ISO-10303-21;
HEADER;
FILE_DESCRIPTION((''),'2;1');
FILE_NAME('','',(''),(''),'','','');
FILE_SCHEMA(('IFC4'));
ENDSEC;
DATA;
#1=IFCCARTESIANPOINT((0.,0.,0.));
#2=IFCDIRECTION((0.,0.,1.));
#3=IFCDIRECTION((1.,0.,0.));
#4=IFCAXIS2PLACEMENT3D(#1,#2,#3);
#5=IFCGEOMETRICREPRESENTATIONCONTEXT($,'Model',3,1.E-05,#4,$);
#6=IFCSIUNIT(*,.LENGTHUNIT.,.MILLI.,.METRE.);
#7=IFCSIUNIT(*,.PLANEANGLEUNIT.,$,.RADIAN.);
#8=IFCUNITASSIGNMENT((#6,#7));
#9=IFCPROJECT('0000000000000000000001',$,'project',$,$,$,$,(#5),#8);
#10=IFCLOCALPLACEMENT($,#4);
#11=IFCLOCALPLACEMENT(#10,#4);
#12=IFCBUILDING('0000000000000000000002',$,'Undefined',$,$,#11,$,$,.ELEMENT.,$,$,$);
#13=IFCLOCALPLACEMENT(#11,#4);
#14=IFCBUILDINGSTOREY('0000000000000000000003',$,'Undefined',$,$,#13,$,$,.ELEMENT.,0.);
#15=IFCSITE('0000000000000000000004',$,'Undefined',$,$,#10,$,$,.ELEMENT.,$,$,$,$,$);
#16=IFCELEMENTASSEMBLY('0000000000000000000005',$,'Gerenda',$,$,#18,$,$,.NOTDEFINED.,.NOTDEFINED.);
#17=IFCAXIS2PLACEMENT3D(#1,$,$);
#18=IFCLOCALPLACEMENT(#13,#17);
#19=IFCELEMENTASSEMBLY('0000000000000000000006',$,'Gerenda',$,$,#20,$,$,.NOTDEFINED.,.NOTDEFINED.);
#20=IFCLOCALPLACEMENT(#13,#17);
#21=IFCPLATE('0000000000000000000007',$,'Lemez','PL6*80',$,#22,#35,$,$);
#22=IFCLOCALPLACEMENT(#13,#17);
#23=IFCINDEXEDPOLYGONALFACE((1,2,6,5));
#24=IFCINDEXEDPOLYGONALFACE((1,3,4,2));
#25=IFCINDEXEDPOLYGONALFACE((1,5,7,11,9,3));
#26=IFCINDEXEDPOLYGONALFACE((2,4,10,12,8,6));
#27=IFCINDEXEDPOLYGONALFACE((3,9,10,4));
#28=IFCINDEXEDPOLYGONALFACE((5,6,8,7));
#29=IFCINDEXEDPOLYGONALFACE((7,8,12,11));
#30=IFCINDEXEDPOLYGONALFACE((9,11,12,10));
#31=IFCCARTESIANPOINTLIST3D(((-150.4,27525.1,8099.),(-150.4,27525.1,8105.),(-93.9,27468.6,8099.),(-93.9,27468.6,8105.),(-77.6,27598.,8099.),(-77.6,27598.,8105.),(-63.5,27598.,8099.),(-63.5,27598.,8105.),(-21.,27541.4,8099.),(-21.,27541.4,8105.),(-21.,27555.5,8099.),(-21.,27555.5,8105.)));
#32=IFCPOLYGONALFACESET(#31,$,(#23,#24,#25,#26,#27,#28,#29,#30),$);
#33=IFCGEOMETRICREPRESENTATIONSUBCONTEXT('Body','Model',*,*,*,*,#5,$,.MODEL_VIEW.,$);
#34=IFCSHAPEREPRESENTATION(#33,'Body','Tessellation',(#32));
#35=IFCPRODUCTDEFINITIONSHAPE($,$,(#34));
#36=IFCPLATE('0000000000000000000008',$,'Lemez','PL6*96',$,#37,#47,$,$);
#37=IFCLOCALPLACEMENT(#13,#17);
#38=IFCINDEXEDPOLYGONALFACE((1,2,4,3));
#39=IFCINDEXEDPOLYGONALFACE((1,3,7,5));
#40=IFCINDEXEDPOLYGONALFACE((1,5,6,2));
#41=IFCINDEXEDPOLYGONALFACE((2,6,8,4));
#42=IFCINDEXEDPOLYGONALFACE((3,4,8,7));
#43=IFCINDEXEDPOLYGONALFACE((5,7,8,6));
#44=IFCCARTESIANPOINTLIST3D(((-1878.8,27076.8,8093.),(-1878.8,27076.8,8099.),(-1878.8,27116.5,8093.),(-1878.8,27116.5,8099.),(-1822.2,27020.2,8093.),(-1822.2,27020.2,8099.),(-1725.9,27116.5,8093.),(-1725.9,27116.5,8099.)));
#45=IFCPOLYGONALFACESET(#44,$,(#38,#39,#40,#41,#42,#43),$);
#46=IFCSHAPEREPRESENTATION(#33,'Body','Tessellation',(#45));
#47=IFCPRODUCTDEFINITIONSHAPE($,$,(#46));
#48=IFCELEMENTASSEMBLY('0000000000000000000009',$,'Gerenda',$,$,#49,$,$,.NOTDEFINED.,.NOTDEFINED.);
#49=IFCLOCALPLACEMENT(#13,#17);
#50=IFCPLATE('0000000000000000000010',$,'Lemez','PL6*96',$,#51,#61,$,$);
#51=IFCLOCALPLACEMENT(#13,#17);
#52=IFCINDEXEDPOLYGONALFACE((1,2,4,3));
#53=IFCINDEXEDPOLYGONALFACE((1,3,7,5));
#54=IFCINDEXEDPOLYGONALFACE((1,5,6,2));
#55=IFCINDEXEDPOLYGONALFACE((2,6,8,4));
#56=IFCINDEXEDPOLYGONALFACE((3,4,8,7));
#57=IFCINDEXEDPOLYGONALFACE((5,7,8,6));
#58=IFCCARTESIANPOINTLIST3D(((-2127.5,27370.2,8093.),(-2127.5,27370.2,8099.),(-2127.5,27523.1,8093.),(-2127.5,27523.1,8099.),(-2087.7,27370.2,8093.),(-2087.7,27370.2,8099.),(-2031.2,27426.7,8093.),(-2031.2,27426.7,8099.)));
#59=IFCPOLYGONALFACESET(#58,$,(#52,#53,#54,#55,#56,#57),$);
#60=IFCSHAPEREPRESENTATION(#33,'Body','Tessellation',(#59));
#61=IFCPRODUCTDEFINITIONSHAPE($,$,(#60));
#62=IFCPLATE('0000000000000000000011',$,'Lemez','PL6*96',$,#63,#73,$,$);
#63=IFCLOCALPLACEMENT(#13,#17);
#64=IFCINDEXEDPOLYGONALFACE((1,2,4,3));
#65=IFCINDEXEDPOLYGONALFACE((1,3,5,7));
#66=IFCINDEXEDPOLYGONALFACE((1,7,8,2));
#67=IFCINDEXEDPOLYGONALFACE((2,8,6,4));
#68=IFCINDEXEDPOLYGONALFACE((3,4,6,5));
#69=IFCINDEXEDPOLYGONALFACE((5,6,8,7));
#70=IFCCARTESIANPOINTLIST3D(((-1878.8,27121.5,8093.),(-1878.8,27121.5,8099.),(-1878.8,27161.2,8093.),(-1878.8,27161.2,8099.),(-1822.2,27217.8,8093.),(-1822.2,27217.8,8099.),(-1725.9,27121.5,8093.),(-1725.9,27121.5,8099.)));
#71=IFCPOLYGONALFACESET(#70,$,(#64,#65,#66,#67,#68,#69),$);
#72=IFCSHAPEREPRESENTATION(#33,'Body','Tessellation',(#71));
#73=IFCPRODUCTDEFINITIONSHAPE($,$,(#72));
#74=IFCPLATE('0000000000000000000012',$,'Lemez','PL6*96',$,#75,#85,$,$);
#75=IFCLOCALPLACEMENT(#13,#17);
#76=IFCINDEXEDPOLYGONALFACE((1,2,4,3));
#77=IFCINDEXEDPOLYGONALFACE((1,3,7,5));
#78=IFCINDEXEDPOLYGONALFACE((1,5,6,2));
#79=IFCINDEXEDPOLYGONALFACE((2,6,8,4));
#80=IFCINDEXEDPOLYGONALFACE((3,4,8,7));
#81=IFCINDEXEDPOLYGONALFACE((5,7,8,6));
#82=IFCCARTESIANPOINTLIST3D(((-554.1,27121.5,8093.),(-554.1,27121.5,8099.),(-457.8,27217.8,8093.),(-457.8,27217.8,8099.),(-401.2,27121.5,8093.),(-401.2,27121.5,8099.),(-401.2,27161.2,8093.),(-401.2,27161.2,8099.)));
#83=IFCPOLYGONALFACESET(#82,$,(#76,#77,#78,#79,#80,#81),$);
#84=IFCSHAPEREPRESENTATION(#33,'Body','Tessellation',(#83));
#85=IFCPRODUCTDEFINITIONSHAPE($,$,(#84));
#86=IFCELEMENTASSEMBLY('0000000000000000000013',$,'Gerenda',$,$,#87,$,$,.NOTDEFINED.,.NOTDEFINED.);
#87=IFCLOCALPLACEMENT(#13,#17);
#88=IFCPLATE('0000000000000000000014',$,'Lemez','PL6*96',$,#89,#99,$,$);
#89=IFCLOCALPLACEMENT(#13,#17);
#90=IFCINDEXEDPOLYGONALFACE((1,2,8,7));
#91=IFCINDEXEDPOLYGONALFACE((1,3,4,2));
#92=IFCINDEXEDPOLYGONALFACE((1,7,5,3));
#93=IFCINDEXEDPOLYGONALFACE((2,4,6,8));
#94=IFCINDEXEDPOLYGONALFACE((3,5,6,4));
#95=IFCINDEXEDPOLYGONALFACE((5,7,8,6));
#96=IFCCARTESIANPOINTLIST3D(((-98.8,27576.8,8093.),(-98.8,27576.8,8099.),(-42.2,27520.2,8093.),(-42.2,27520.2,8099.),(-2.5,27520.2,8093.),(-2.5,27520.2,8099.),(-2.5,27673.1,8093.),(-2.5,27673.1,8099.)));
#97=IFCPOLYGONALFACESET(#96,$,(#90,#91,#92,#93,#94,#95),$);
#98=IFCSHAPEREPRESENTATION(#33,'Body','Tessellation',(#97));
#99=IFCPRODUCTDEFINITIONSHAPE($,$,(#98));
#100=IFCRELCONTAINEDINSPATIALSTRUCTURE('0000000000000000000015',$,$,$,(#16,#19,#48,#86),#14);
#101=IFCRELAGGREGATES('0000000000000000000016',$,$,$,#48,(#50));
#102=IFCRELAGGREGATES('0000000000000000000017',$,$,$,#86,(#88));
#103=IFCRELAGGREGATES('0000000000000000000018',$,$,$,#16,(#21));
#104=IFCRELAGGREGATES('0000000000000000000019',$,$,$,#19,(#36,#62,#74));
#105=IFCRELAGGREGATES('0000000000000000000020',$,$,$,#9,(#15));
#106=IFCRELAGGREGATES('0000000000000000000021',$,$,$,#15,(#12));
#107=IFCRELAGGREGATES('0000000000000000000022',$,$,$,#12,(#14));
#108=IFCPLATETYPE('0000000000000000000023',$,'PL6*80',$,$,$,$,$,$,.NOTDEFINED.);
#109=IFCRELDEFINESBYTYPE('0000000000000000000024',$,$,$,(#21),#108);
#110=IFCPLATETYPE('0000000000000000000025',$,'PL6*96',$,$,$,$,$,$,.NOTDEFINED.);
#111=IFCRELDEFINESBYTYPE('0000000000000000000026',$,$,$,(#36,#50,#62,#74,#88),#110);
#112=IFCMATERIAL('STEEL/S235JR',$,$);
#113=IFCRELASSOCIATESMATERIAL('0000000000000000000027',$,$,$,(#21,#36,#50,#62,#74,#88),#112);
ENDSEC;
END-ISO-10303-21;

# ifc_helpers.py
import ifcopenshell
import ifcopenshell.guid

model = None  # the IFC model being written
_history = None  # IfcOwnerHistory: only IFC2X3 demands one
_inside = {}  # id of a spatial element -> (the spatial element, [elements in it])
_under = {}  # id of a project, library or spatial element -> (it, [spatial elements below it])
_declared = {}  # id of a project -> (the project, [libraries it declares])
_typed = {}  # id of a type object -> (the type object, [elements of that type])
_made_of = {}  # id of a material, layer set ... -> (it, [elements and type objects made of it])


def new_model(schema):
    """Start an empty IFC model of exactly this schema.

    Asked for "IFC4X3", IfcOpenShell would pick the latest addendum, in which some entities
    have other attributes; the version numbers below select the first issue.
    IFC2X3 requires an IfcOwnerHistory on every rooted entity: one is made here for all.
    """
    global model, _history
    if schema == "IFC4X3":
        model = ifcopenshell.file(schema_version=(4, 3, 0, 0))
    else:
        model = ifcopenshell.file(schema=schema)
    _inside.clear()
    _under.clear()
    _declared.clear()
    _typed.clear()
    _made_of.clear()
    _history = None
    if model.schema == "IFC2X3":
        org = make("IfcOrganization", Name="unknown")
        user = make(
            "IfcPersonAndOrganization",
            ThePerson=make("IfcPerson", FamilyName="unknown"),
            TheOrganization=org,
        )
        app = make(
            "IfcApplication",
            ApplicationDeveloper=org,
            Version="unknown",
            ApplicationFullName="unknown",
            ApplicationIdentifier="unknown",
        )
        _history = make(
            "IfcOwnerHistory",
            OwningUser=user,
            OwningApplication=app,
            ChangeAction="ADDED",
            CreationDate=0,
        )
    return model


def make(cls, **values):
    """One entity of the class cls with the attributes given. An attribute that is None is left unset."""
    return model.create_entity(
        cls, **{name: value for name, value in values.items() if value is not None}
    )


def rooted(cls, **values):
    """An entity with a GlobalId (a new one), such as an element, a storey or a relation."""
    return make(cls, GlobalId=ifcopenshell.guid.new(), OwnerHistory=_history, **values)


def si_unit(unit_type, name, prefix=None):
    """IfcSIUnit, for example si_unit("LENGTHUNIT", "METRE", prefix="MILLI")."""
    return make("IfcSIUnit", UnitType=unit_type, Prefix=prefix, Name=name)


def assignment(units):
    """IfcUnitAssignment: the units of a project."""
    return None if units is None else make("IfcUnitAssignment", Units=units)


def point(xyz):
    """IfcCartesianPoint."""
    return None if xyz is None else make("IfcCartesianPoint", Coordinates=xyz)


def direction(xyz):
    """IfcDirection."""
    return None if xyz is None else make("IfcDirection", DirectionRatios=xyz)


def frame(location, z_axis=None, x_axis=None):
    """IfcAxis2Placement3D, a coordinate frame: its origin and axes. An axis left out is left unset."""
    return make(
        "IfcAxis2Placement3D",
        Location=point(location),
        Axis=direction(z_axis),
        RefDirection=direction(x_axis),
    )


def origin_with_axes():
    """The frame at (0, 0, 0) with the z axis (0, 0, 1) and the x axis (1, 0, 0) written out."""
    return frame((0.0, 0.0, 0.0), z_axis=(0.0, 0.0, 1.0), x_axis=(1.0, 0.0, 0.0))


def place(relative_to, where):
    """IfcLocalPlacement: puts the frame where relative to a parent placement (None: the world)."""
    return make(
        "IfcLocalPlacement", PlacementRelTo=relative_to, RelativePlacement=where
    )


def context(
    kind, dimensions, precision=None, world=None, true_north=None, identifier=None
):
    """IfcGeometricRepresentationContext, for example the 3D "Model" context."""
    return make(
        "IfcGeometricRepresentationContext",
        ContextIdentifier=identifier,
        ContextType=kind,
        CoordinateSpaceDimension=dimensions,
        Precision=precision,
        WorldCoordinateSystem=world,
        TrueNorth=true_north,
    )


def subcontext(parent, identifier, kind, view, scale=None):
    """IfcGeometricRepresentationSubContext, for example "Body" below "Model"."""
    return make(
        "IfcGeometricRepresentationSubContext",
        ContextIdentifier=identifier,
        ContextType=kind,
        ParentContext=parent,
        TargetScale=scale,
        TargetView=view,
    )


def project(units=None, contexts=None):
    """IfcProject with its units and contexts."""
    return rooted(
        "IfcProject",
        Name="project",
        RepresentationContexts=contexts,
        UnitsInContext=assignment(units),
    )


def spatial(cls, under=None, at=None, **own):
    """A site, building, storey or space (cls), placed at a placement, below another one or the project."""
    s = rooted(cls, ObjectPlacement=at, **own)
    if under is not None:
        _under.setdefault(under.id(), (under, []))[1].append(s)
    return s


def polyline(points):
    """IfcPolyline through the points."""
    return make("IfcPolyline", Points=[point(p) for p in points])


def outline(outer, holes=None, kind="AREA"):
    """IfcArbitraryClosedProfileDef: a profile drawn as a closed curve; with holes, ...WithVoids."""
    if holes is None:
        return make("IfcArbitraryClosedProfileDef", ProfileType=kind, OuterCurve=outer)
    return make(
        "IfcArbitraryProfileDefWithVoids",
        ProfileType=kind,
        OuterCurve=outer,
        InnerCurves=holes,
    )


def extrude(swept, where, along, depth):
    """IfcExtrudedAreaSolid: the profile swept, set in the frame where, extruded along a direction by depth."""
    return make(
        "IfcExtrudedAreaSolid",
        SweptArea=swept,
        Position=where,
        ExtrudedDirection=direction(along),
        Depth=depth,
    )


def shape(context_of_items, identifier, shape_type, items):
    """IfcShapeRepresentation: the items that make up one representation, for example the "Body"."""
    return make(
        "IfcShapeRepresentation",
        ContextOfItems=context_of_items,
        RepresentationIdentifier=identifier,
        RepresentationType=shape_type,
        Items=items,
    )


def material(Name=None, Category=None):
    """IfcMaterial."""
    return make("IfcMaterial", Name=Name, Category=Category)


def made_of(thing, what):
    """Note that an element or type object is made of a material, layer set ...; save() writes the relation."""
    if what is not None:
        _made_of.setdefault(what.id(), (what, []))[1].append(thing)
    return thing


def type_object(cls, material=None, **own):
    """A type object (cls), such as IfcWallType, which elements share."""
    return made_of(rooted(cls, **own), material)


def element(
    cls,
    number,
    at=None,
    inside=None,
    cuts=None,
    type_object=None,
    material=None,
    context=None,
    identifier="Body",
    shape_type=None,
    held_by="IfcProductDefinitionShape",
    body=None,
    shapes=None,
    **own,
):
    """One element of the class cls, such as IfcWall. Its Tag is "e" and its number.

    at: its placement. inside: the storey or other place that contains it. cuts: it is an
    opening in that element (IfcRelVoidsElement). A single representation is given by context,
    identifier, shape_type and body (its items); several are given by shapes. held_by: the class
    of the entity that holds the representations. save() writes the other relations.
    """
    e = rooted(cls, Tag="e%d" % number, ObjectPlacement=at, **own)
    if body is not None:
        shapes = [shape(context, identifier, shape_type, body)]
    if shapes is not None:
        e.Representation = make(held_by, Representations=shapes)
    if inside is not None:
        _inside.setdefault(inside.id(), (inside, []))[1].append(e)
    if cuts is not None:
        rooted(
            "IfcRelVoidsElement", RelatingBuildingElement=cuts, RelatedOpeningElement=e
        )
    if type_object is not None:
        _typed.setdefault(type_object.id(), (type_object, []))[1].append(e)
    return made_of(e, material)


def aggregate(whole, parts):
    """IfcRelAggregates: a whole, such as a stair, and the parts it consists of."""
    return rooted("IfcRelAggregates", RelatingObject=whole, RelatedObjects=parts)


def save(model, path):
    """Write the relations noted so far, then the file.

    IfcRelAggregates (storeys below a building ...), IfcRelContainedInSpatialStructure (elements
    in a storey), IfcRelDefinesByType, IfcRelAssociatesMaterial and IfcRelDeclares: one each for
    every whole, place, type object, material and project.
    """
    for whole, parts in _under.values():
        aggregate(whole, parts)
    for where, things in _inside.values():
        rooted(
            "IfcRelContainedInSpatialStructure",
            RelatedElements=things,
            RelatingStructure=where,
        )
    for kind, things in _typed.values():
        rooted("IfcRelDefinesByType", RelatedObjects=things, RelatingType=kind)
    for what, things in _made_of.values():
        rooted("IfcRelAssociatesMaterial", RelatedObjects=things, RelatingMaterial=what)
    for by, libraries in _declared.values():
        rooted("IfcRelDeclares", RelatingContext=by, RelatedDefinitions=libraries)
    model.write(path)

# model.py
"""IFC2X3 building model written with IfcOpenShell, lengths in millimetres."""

from ifc_helpers import new_model, si_unit, frame, origin_with_axes, place, context, subcontext, project, spatial, polyline, outline, extrude, material, type_object, element, aggregate, save


model = new_model("IFC2X3")

# Units and contexts
model_context = context("Model", 3, precision=1e-05, world=origin_with_axes())
body_context = subcontext(model_context, "Body", "Model", "MODEL_VIEW")
ifc_project = project(units=[si_unit("LENGTHUNIT", "METRE", prefix="MILLI"), si_unit("PLANEANGLEUNIT", "RADIAN")], contexts=[model_context])

# Site, building, storey
site_placement = place(None, origin_with_axes())
site = spatial("IfcSite", under=ifc_project, at=site_placement, Name="Undefined", CompositionType="ELEMENT")
building_placement = place(site_placement, origin_with_axes())
building = spatial("IfcBuilding", under=site, at=building_placement, Name="Undefined", CompositionType="ELEMENT")
storey_placement = place(building_placement, origin_with_axes())
storey = spatial("IfcBuildingStorey", under=building, at=storey_placement, Name="Undefined", CompositionType="ELEMENT", Elevation=0.0)

# Element assemblies
ifc_material_1 = material(Name="STEEL/S235JR")
assembly_1_placement = place(storey_placement, origin_with_axes())
assembly_1 = element("IfcElementAssembly", 1, at=assembly_1_placement, inside=storey, Name="Gerenda", AssemblyPlace="NOTDEFINED", PredefinedType="NOTDEFINED")
assembly_2_placement = place(storey_placement, origin_with_axes())
assembly_2 = element("IfcElementAssembly", 2, at=assembly_2_placement, inside=storey, Name="Gerenda", AssemblyPlace="NOTDEFINED", PredefinedType="NOTDEFINED")

# Plates
plate_type_1 = type_object("IfcPlateType", Name="PL6*80", PredefinedType="NOTDEFINED")
plate_1_placement = place(assembly_1_placement, frame((-21.0, 27541.4, 8102.0), z_axis=(0.0, 0.0, 1.0), x_axis=(0.000007, 1.0, 0.0)))
plate_1 = element("IfcPlate", 3, at=plate_1_placement, type_object=plate_type_1, material=ifc_material_1, Name="Lemez", Description="PL6*80", context=body_context, shape_type="SweptSolid", body=[
    extrude(outline(polyline([(0.0, 0.0), (14.1, 0.0), (56.6, 42.4), (56.6, 56.6), (-16.3, 129.4), (-72.8, 72.8), (0.0, 0.0)])), frame((0.0, 0.0, -3.0), z_axis=(0.0, 0.0, 1.0), x_axis=(1.0, 0.0, 0.0)), (0.0, 0.0, 1.0), 6.0),
])
plate_type_2 = type_object("IfcPlateType", Name="PL6*96", PredefinedType="NOTDEFINED")
plate_2_placement = place(assembly_2_placement, frame((-1725.9, 27116.5, 8096.0), z_axis=(0.0, 0.0, 1.0), x_axis=(-1.0, 0.000003, 0.0)))
plate_2 = element("IfcPlate", 4, at=plate_2_placement, type_object=plate_type_2, material=ifc_material_1, Name="Lemez", Description="PL6*96", context=body_context, shape_type="SweptSolid", body=[
    extrude(outline(polyline([(0.0, 0.0), (152.9, 0.0), (152.9, 39.7), (96.3, 96.3), (0.0, 0.0)])), frame((0.0, 0.0, -3.0), z_axis=(0.0, 0.0, 1.0), x_axis=(1.0, 0.0, 0.0)), (0.0, 0.0, 1.0), 6.0),
])

# Element assembly, plate
assembly_3_placement = place(storey_placement, origin_with_axes())
assembly_3 = element("IfcElementAssembly", 5, at=assembly_3_placement, inside=storey, Name="Gerenda", AssemblyPlace="NOTDEFINED", PredefinedType="NOTDEFINED")
plate_3_placement = place(assembly_3_placement, frame((-2127.5, 27523.1, 8096.0), z_axis=(0.0, 0.0, 1.0), x_axis=(-0.000004, -1.0, 0.0)))
plate_3 = element("IfcPlate", 6, at=plate_3_placement, type_object=plate_type_2, material=ifc_material_1, Name="Lemez", Description="PL6*96", context=body_context, shape_type="SweptSolid", body=[
    extrude(outline(polyline([(0.0, 0.0), (152.9, 0.0), (152.9, 39.7), (96.3, 96.3), (0.0, 0.0)])), frame((0.0, 0.0, -3.0), z_axis=(0.0, 0.0, 1.0), x_axis=(1.0, 0.0, 0.0)), (0.0, 0.0, 1.0), 6.0),
])
aggregate(assembly_3, [plate_3])

# Plates
plate_4_placement = place(assembly_2_placement, frame((-1878.8, 27121.5, 8096.0), z_axis=(0.0, 0.0, 1.0), x_axis=(1.0, -0.000003, 0.0)))
plate_4 = element("IfcPlate", 7, at=plate_4_placement, type_object=plate_type_2, material=ifc_material_1, Name="Lemez", Description="PL6*96", context=body_context, shape_type="SweptSolid", body=[
    extrude(outline(polyline([(0.0, 0.0), (152.9, 0.0), (56.6, 96.3), (0.0, 39.7), (0.0, 0.0)])), frame((0.0, 0.0, -3.0), z_axis=(0.0, 0.0, 1.0), x_axis=(1.0, 0.0, 0.0)), (0.0, 0.0, 1.0), 6.0),
])
plate_5_placement = place(assembly_2_placement, frame((-554.1, 27121.5, 8096.0), z_axis=(0.0, 0.0, 1.0), x_axis=(1.0, -0.000003, 0.0)))
plate_5 = element("IfcPlate", 8, at=plate_5_placement, type_object=plate_type_2, material=ifc_material_1, Name="Lemez", Description="PL6*96", context=body_context, shape_type="SweptSolid", body=[
    extrude(outline(polyline([(0.0, 0.0), (152.9, 0.0), (152.9, 39.7), (96.3, 96.3), (0.0, 0.0)])), frame((0.0, 0.0, -3.0), z_axis=(0.0, 0.0, 1.0), x_axis=(1.0, 0.0, 0.0)), (0.0, 0.0, 1.0), 6.0),
])

# Element assembly, plate
assembly_4_placement = place(storey_placement, origin_with_axes())
assembly_4 = element("IfcElementAssembly", 9, at=assembly_4_placement, inside=storey, Name="Gerenda", AssemblyPlace="NOTDEFINED", PredefinedType="NOTDEFINED")
plate_6_placement = place(assembly_4_placement, frame((-2.5, 27520.2, 8096.0), z_axis=(0.0, 0.0, 1.0), x_axis=(0.000003, 1.0, 0.0)))
plate_6 = element("IfcPlate", 10, at=plate_6_placement, type_object=plate_type_2, material=ifc_material_1, Name="Lemez", Description="PL6*96", context=body_context, shape_type="SweptSolid", body=[
    extrude(outline(polyline([(0.0, 0.0), (152.9, 0.0), (56.6, 96.3), (0.0, 39.7), (0.0, 0.0)])), frame((0.0, 0.0, -3.0), z_axis=(0.0, 0.0, 1.0), x_axis=(1.0, 0.0, 0.0)), (0.0, 0.0, 1.0), 6.0),
])
aggregate(assembly_4, [plate_6])

aggregate(assembly_1, [plate_1])
aggregate(assembly_2, [plate_2, plate_4, plate_5])

save(model, "model.ifc")
